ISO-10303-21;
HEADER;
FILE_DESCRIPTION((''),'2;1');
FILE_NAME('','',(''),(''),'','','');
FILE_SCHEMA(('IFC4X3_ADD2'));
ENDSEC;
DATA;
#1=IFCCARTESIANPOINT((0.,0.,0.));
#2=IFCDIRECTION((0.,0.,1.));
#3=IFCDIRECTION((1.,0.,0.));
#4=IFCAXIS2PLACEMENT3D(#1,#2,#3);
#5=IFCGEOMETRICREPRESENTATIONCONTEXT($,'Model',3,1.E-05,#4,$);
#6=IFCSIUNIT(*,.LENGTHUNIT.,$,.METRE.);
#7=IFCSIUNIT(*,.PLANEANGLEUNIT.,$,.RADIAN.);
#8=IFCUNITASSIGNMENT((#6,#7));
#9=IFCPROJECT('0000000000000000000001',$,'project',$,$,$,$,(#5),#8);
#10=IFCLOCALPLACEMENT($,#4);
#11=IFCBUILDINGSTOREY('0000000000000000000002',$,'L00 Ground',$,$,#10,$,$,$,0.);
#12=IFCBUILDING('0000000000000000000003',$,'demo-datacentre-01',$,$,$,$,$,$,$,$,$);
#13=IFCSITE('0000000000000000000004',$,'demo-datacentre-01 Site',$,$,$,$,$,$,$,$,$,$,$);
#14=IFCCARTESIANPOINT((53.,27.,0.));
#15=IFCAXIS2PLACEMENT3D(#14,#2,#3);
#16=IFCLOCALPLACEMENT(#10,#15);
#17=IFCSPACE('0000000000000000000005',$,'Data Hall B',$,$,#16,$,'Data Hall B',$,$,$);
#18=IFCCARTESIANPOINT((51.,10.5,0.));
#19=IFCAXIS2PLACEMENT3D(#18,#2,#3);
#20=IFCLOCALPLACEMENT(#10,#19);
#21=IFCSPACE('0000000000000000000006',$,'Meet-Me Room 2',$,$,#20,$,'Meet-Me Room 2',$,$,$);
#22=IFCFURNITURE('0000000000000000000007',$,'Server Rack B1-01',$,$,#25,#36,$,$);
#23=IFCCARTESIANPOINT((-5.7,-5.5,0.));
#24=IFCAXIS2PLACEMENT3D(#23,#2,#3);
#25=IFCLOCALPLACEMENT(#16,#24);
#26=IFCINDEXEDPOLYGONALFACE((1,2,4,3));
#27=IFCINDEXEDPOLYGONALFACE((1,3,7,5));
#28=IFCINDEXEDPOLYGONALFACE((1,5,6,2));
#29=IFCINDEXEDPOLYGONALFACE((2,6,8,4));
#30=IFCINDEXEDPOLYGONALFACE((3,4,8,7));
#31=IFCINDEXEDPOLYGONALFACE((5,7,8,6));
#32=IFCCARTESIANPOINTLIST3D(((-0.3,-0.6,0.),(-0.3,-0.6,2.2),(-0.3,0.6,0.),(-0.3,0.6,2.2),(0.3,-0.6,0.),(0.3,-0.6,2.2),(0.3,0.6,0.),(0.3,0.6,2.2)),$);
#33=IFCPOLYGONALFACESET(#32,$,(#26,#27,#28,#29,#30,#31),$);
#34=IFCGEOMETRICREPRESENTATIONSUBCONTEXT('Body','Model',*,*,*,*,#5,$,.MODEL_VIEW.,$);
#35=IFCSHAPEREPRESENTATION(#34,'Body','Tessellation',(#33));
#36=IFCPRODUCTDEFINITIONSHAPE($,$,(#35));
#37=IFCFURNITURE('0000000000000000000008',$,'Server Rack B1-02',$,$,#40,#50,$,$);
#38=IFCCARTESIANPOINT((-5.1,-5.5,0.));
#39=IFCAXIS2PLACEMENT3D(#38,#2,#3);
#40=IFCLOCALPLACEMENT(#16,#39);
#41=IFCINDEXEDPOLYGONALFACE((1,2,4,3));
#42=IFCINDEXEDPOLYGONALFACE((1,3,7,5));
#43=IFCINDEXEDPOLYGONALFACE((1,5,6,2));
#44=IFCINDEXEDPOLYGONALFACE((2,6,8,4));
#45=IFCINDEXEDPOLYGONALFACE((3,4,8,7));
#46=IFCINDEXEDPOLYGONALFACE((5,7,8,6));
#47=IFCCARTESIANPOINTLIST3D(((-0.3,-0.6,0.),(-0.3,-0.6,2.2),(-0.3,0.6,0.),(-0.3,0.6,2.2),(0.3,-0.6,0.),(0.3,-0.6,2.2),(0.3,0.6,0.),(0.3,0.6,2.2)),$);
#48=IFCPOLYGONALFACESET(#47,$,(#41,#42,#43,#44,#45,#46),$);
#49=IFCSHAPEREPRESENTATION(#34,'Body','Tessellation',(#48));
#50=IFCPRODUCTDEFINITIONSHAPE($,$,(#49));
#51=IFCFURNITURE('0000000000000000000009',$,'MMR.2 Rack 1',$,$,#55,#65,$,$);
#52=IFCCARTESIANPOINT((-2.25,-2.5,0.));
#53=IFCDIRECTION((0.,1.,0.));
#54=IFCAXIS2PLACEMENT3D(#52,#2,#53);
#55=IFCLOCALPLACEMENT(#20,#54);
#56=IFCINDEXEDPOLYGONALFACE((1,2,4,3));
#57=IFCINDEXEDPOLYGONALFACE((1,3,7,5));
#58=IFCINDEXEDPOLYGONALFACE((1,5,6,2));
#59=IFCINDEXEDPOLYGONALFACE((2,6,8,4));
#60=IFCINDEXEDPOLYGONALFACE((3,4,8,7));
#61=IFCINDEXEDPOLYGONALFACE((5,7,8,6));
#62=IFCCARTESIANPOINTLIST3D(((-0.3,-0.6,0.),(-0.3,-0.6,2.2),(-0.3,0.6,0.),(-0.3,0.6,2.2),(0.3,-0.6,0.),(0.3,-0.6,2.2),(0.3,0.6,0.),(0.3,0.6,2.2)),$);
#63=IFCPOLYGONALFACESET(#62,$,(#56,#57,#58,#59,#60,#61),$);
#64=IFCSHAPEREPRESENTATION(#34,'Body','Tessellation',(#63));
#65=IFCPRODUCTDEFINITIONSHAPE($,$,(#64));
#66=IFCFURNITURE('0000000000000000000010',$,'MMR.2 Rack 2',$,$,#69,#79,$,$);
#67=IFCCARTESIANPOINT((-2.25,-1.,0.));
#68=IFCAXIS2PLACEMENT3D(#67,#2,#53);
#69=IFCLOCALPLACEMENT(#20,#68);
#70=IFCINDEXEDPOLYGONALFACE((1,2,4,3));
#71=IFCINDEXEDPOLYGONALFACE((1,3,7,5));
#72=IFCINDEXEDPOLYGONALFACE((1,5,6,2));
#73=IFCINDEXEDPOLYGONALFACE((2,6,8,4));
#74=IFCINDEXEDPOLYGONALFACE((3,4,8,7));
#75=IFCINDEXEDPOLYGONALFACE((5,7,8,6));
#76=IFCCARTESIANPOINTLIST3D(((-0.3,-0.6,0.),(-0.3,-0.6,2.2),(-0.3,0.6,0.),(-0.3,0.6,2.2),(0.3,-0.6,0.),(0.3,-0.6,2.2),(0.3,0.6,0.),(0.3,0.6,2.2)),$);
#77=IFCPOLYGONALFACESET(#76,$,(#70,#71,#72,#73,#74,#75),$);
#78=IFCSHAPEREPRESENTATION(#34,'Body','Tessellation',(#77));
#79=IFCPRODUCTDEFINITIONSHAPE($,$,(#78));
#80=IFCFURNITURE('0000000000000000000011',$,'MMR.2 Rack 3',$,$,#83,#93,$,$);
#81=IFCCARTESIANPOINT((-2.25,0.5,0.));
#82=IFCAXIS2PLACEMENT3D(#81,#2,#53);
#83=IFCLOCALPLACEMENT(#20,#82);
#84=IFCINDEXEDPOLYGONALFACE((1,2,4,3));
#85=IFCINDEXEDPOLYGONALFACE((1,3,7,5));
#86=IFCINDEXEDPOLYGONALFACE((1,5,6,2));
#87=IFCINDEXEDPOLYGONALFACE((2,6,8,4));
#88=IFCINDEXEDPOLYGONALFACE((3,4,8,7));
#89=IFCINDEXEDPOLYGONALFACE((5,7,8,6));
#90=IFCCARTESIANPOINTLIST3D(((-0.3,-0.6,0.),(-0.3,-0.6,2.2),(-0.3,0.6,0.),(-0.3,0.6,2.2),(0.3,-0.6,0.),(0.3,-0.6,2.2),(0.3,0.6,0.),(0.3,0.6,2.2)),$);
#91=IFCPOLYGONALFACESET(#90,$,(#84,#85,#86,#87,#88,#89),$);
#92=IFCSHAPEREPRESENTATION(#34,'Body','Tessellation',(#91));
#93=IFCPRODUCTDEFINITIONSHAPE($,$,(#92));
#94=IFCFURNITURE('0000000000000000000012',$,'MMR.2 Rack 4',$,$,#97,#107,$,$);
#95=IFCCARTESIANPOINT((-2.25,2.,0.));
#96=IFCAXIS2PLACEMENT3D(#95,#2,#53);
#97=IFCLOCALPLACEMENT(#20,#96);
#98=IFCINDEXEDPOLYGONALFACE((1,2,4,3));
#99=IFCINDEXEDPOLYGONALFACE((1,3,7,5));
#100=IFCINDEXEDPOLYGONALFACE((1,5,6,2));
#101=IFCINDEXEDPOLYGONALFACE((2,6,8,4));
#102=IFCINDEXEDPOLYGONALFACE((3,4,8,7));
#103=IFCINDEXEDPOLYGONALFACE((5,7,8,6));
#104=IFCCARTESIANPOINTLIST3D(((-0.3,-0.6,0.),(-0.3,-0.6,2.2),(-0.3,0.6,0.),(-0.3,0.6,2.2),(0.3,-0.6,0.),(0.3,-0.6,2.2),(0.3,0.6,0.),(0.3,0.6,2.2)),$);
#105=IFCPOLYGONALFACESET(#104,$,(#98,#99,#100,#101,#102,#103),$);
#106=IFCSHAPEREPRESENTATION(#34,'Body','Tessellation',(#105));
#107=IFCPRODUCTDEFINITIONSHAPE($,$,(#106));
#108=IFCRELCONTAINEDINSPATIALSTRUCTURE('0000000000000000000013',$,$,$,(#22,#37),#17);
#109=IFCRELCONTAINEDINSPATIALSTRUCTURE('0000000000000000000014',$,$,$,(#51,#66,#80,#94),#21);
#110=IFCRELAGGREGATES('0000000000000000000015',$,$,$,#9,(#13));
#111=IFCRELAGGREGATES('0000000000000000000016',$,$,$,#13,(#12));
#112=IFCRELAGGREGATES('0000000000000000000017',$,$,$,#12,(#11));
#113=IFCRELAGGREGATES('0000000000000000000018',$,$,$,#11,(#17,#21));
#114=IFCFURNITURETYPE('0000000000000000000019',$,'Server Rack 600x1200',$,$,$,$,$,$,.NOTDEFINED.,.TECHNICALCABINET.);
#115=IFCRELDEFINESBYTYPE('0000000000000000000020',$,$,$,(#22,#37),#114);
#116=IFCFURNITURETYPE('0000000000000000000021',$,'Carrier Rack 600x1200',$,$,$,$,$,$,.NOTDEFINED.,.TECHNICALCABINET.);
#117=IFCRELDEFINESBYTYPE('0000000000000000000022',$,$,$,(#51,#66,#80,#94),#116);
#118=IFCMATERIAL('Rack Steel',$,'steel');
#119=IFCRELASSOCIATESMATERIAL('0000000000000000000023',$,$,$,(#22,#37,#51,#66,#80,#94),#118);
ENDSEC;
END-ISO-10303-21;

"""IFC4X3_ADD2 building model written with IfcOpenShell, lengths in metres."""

from ifc_helpers import new_model, si_unit, frame, origin_with_axes, place, context, subcontext, project, spatial, rectangle, extrude, material, type_object, element, save


model = new_model("IFC4X3_ADD2")

# Units and contexts
model_context = context("Model", 3, precision=1e-05, world=origin_with_axes())
body_context = subcontext(model_context, "Body", "Model", "MODEL_VIEW")
ifc_project = project(units=[si_unit("LENGTHUNIT", "METRE"), si_unit("PLANEANGLEUNIT", "RADIAN")], contexts=[model_context])

# Site, building, storey
site = spatial("IfcSite", under=ifc_project, Name="demo-datacentre-01 Site")
building = spatial("IfcBuilding", under=site, Name="demo-datacentre-01")
storey_placement = place(None, origin_with_axes())
storey = spatial("IfcBuildingStorey", under=building, at=storey_placement, Name="L00 Ground", Elevation=0.0)

# Shared definitions
space_1_placement = place(storey_placement, frame((53.0, 27.0, 0.0), z_axis=(0.0, 0.0, 1.0), x_axis=(1.0, 0.0, 0.0)))
space_1 = spatial("IfcSpace", under=storey, at=space_1_placement, Name="Data Hall B", LongName="Data Hall B")

# Furniture
ifc_material_1 = material(Name="Rack Steel", Category="steel")
furniture_type_1 = type_object("IfcFurnitureType", Name="Server Rack 600x1200", AssemblyPlace="NOTDEFINED", PredefinedType="TECHNICALCABINET")
for number, where, z_axis, x_axis, name in (
    (1, (-5.7, -5.5, 0.0), (0.0, 0.0, 1.0), (1.0, 0.0, 0.0), "Server Rack B1-01"),
    (2, (-5.1, -5.5, 0.0), (0.0, 0.0, 1.0), (1.0, 0.0, 0.0), "Server Rack B1-02"),
):
    element("IfcFurniture", number, at=place(space_1_placement, frame(where, z_axis=z_axis, x_axis=x_axis)), inside=space_1, type_object=furniture_type_1, material=ifc_material_1, Name=name, context=body_context, shape_type="SweptSolid", body=[
        extrude(rectangle(XDim=0.6, YDim=1.2), origin_with_axes(), (0.0, 0.0, 1.0), 2.2),
    ])

# Shared definitions
space_2_placement = place(storey_placement, frame((51.0, 10.5, 0.0), z_axis=(0.0, 0.0, 1.0), x_axis=(1.0, 0.0, 0.0)))
space_2 = spatial("IfcSpace", under=storey, at=space_2_placement, Name="Meet-Me Room 2", LongName="Meet-Me Room 2")

# Furniture
furniture_type_2 = type_object("IfcFurnitureType", Name="Carrier Rack 600x1200", AssemblyPlace="NOTDEFINED", PredefinedType="TECHNICALCABINET")
for number, where, z_axis, x_axis, name in (
    (3, (-2.25, -2.5, 0.0), (0.0, 0.0, 1.0), (0.0, 1.0, 0.0), "MMR.2 Rack 1"),
    (4, (-2.25, -1.0, 0.0), (0.0, 0.0, 1.0), (0.0, 1.0, 0.0), "MMR.2 Rack 2"),
    (5, (-2.25, 0.5, 0.0), (0.0, 0.0, 1.0), (0.0, 1.0, 0.0), "MMR.2 Rack 3"),
    (6, (-2.25, 2.0, 0.0), (0.0, 0.0, 1.0), (0.0, 1.0, 0.0), "MMR.2 Rack 4"),
):
    element("IfcFurniture", number, at=place(space_2_placement, frame(where, z_axis=z_axis, x_axis=x_axis)), inside=space_2, type_object=furniture_type_2, material=ifc_material_1, Name=name, context=body_context, shape_type="SweptSolid", body=[
        extrude(rectangle(XDim=0.6, YDim=1.2), origin_with_axes(), (0.0, 0.0, 1.0), 2.2),
    ])

save(model, "model.ifc")
